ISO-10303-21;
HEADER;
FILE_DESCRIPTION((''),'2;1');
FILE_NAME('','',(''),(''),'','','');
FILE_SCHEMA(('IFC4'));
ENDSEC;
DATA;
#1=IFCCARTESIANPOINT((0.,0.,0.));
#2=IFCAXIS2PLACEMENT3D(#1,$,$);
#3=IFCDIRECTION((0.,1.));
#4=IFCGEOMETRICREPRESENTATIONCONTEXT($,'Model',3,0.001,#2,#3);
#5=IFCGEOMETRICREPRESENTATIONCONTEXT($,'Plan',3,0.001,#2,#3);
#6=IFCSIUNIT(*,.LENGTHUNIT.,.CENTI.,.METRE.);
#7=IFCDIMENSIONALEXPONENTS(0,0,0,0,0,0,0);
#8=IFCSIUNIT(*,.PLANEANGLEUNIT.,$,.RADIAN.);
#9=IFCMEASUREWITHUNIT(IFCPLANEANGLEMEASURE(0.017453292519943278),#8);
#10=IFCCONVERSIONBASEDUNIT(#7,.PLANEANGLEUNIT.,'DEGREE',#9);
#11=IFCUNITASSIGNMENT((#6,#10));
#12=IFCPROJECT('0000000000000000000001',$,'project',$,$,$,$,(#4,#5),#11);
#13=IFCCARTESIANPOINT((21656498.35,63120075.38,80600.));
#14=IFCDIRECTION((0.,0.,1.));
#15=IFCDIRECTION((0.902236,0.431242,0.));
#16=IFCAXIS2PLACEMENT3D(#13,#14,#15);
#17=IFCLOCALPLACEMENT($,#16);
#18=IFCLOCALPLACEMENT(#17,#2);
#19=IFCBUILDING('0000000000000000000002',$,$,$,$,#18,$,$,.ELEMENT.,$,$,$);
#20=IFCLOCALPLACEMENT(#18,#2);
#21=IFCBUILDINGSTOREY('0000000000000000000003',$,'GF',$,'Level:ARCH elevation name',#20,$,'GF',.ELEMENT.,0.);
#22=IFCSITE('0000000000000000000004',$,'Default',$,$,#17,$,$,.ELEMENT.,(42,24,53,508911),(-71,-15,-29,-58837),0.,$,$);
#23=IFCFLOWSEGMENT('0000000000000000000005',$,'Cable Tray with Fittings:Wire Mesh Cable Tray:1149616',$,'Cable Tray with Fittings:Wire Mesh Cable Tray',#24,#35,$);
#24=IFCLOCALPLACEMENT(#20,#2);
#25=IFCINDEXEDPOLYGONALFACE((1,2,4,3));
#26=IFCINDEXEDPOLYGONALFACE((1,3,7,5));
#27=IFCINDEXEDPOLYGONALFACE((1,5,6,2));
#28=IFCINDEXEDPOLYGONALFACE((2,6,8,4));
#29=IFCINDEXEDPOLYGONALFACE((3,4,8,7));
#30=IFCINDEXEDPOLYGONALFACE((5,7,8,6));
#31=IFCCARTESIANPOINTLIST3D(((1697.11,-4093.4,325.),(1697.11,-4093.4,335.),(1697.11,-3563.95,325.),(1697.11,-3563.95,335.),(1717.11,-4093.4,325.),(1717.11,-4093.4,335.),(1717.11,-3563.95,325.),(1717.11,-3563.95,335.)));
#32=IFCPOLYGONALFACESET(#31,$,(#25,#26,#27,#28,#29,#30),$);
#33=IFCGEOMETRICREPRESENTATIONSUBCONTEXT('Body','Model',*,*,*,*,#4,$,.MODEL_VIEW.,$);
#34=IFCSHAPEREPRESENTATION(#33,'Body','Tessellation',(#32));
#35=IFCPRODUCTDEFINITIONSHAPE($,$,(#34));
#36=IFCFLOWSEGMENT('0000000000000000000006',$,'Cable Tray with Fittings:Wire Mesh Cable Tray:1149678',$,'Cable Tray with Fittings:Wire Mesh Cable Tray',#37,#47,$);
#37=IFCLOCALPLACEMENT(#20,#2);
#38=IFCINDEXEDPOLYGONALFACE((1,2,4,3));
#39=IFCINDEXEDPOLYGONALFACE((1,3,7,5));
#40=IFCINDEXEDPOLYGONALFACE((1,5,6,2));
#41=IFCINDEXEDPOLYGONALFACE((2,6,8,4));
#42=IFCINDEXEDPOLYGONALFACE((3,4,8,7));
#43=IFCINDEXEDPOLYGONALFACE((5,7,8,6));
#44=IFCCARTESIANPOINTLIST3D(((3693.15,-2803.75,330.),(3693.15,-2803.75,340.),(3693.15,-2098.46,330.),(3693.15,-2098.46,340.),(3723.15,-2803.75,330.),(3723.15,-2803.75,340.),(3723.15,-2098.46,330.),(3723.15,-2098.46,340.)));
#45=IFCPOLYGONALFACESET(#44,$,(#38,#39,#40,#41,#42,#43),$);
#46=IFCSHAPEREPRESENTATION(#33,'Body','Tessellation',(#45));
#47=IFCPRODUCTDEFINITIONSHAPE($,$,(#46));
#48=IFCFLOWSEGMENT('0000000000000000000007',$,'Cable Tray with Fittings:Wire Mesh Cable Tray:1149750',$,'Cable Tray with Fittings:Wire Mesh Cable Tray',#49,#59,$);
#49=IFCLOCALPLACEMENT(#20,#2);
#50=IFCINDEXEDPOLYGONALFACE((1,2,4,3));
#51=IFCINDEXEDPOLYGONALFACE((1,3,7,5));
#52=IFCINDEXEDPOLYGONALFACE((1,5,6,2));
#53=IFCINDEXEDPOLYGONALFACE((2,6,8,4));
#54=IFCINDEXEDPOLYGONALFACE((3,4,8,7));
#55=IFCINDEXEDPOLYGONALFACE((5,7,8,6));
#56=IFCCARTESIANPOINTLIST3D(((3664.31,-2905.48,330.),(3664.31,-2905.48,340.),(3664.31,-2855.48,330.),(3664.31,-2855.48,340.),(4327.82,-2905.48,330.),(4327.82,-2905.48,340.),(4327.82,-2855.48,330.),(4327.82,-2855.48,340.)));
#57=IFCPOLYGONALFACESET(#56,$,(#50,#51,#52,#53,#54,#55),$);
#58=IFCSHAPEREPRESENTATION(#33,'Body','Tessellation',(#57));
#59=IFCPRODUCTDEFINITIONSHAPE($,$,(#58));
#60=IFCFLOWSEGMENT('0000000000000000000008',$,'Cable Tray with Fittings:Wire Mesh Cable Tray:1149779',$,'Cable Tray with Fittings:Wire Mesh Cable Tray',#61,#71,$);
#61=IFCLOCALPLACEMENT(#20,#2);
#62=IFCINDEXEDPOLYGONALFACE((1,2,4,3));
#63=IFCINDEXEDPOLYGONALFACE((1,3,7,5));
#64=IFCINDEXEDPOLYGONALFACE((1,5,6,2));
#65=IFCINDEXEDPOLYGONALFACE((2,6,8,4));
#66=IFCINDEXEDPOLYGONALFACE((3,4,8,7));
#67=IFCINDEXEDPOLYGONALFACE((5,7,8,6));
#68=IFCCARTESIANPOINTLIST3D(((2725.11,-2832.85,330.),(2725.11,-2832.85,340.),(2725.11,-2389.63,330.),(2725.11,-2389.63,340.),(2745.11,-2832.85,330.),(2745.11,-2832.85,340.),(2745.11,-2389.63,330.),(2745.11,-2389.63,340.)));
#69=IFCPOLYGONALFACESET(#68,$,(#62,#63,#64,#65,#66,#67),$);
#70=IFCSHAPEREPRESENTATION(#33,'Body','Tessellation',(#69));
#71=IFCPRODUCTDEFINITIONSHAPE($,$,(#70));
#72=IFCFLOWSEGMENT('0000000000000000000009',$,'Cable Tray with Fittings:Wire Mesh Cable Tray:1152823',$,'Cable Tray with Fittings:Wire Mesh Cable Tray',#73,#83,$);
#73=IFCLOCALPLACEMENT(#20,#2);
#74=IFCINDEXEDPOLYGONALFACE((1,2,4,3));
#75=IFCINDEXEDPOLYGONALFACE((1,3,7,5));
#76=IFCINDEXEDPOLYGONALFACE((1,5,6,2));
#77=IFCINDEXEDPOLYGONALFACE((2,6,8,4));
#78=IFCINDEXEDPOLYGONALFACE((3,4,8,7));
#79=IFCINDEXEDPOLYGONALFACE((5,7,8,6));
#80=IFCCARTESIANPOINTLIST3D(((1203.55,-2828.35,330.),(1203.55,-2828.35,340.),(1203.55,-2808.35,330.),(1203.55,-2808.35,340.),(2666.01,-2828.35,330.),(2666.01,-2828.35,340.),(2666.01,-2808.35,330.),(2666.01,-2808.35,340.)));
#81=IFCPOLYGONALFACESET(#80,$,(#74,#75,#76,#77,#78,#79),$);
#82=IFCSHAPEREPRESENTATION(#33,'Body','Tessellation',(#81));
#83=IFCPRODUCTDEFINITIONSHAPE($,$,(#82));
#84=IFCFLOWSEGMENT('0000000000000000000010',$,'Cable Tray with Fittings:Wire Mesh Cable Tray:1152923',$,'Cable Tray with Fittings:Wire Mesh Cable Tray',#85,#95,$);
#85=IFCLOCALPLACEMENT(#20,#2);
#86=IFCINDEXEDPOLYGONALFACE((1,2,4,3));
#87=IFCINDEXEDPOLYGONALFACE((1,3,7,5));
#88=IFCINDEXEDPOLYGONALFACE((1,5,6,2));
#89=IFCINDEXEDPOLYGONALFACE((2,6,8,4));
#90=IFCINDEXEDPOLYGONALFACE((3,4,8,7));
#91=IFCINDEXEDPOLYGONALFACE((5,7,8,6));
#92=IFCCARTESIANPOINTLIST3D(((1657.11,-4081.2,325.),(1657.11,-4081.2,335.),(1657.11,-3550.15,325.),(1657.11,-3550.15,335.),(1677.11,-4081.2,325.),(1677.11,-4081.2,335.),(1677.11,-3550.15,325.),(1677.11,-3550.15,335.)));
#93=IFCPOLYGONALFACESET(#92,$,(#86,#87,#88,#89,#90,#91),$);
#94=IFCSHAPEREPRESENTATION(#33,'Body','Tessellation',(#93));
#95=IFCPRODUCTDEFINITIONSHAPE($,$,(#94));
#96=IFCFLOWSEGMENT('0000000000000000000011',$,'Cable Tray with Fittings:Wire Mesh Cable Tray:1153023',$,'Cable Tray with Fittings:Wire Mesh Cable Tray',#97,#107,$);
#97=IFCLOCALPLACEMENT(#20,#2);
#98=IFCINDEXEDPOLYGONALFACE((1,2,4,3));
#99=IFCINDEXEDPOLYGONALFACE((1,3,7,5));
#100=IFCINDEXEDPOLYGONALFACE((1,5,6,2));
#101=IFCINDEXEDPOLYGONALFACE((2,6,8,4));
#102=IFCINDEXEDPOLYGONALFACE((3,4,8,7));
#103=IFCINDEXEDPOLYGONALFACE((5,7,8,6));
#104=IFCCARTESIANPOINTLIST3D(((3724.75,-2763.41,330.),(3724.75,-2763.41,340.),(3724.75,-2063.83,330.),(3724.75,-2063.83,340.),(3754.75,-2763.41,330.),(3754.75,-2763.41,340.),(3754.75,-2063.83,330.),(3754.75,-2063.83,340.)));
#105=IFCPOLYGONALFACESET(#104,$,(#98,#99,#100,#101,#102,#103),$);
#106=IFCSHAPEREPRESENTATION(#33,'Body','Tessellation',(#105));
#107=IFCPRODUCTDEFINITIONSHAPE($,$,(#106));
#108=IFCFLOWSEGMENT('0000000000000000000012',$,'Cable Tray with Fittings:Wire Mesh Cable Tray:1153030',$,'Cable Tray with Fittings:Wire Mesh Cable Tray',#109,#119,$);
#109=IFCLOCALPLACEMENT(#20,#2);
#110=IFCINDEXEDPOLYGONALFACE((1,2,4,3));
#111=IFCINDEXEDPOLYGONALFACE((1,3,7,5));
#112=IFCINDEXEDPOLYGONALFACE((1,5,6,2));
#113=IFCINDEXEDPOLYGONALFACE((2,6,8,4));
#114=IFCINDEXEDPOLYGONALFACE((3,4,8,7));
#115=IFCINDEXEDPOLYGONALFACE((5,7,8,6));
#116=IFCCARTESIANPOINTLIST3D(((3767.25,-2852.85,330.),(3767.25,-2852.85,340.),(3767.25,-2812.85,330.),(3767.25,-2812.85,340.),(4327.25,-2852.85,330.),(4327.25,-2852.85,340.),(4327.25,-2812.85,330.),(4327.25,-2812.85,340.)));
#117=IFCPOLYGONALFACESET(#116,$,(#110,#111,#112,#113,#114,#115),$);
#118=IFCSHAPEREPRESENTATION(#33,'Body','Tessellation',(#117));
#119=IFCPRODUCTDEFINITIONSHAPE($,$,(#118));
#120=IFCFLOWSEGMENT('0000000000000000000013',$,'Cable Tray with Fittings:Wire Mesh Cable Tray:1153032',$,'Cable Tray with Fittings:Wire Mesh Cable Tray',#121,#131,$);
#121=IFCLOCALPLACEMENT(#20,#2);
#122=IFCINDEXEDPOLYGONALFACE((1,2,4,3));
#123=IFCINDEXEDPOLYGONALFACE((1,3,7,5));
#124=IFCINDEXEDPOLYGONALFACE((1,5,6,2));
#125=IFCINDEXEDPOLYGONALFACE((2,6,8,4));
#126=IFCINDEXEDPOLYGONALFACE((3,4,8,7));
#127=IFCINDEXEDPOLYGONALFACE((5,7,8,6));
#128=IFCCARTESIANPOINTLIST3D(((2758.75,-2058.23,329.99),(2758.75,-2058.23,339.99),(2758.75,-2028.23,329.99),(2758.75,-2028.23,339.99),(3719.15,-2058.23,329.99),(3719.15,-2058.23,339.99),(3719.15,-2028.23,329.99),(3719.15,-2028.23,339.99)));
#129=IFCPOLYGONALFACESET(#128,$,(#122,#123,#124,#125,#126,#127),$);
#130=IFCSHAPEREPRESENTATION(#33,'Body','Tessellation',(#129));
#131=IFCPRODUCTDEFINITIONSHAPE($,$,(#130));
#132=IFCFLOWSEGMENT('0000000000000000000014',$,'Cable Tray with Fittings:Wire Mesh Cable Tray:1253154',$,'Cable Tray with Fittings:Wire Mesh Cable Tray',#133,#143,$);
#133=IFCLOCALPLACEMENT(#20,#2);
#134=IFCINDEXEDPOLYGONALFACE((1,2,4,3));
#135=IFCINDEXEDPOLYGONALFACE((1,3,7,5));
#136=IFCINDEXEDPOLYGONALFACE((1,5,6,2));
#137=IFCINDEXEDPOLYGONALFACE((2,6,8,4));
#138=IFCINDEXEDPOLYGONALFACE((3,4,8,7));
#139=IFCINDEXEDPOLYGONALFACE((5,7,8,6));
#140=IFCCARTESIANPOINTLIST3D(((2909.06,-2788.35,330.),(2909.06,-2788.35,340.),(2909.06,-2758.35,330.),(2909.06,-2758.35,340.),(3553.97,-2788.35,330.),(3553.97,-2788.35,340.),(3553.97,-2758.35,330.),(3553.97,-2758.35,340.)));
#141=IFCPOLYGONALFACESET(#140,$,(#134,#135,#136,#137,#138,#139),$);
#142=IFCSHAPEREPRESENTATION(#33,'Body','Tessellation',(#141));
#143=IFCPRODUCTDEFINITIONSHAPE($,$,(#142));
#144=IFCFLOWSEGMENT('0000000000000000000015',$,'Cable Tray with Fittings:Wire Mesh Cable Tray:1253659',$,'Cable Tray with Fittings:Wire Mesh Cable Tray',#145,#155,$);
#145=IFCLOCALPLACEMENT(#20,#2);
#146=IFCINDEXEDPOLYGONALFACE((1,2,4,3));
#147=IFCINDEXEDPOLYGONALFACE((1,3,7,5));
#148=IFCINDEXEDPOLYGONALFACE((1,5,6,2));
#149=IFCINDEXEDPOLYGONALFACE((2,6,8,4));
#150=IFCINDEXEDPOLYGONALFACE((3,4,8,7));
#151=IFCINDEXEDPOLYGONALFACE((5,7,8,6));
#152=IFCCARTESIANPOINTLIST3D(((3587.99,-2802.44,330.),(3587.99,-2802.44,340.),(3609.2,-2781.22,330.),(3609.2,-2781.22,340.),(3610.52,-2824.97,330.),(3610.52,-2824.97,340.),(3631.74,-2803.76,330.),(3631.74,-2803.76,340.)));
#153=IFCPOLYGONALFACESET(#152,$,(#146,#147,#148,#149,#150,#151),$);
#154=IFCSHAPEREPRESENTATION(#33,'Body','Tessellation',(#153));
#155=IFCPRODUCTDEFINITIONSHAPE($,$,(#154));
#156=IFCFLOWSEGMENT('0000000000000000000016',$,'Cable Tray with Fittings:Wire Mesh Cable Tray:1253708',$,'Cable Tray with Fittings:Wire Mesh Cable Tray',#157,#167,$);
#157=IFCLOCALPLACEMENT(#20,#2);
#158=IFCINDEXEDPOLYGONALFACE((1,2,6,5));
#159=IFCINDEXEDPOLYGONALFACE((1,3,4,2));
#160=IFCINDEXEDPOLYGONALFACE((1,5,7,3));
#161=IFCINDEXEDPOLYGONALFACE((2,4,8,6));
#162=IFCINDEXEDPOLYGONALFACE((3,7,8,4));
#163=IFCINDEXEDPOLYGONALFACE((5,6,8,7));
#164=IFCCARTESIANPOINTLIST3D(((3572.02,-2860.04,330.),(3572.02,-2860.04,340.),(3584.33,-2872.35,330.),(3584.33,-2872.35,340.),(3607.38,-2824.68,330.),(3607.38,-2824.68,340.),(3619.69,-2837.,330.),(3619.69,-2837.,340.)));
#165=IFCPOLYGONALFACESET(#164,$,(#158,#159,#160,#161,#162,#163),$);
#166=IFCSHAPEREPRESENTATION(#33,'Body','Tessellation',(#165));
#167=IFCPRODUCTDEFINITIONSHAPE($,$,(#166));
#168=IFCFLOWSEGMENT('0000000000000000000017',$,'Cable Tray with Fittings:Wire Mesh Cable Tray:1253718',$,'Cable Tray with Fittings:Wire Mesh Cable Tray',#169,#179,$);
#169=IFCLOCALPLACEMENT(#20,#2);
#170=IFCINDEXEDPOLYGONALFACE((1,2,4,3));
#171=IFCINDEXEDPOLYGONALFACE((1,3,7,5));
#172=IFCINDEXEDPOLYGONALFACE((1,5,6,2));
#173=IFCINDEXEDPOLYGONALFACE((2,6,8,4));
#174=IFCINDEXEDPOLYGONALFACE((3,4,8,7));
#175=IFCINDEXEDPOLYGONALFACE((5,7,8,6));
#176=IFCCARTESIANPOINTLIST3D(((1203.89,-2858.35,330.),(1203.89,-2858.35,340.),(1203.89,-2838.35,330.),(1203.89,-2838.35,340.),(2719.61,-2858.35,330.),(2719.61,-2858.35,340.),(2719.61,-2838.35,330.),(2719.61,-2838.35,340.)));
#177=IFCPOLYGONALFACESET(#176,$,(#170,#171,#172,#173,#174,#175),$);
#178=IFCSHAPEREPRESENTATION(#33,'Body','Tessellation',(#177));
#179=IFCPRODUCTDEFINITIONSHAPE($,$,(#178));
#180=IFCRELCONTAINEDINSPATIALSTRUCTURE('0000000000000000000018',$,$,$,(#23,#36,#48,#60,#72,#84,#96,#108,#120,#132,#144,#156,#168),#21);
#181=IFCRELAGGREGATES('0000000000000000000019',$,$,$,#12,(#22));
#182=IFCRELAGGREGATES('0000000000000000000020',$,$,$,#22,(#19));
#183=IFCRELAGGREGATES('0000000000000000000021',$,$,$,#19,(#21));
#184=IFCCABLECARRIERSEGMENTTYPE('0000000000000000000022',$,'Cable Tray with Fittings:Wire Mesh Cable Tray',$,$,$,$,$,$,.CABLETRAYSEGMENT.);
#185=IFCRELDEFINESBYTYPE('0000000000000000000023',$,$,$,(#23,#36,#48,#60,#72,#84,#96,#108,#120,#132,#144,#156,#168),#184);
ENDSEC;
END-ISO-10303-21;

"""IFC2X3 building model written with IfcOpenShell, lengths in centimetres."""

from ifc_helpers import new_model, entity, si_unit, converted_unit, direction, frame, frame_2d, origin, origin_2d_with_axis, place, context, subcontext, project, spatial, rectangle, extrude, type_object, element, save


model = new_model("IFC2X3")

# Units and contexts
model_context = context("Model", 3, precision=0.001, world=origin(), true_north=direction((0.0, 1.0)))
plan_context = context("Plan", 3, precision=0.001, world=origin(), true_north=direction((0.0, 1.0)))
body_context = subcontext(model_context, "Body", "Model", "MODEL_VIEW")
ifc_project = project(units=[si_unit("LENGTHUNIT", "METRE", prefix="CENTI"), converted_unit("PLANEANGLEUNIT", "DEGREE", entity("IfcPlaneAngleMeasure", 0.017453292519943278), si_unit("PLANEANGLEUNIT", "RADIAN"), dimensions=[0, 0, 0, 0, 0, 0, 0])], contexts=[model_context, plan_context])

# Site, building, storey
site_placement = place(None, frame((21656498.35, 63120075.38, 80600.0), z_axis=(0.0, 0.0, 1.0), x_axis=(0.902236, 0.431242, 0.0)))
site = spatial("IfcSite", under=ifc_project, at=site_placement, Name="Default", CompositionType="ELEMENT", RefLatitude=(42, 24, 53, 508911), RefLongitude=(-71, -15, -29, -58837), RefElevation=0.0)
building_placement = place(site_placement, origin())
building = spatial("IfcBuilding", under=site, at=building_placement, CompositionType="ELEMENT")
storey_placement = place(building_placement, origin())
storey = spatial("IfcBuildingStorey", under=building, at=storey_placement, Name="GF", ObjectType="Level:ARCH elevation name", LongName="GF", CompositionType="ELEMENT", Elevation=0.0)

# Flow segments
cable_carrier_segment_type_1 = type_object("IfcCableCarrierSegmentType", Name="Cable Tray with Fittings:Wire Mesh Cable Tray", PredefinedType="CABLETRAYSEGMENT")
flow_segment_1_placement = place(storey_placement, origin())
element("IfcFlowSegment", 1, at=flow_segment_1_placement, inside=storey, type_object=cable_carrier_segment_type_1, Name="Cable Tray with Fittings:Wire Mesh Cable Tray:1149616", ObjectType="Cable Tray with Fittings:Wire Mesh Cable Tray", context=body_context, shape_type="SweptSolid", body=[
    extrude(rectangle(XDim=529.45, YDim=20.0, at=frame_2d((0.0, 0.0), x_axis=(1.0, 0.0))), frame((1707.11, -3828.68, 325.0), z_axis=(0.0, 0.0, 1.0), x_axis=(0.0, 1.0, 0.0)), (0.0, 0.0, 1.0), 10.0),
])
flow_segment_2_placement = place(storey_placement, origin())
element("IfcFlowSegment", 2, at=flow_segment_2_placement, inside=storey, type_object=cable_carrier_segment_type_1, Name="Cable Tray with Fittings:Wire Mesh Cable Tray:1149678", ObjectType="Cable Tray with Fittings:Wire Mesh Cable Tray", context=body_context, shape_type="SweptSolid", body=[
    extrude(rectangle(XDim=705.29, YDim=30.0, at=frame_2d((0.0, 0.0), x_axis=(1.0, 0.0))), frame((3708.15, -2451.1, 330.0), z_axis=(0.0, 0.0, 1.0), x_axis=(0.0, -1.0, 0.0)), (0.0, 0.0, 1.0), 10.0),
])
flow_segment_3_placement = place(storey_placement, origin())
element("IfcFlowSegment", 3, at=flow_segment_3_placement, inside=storey, type_object=cable_carrier_segment_type_1, Name="Cable Tray with Fittings:Wire Mesh Cable Tray:1149750", ObjectType="Cable Tray with Fittings:Wire Mesh Cable Tray", context=body_context, shape_type="SweptSolid", body=[
    extrude(rectangle(XDim=663.51, YDim=50.0, at=frame_2d((0.0, 0.0), x_axis=(1.0, 0.0))), frame((3996.06, -2880.48, 330.0)), (0.0, 0.0, 1.0), 10.0),
])
flow_segment_4_placement = place(storey_placement, origin())
element("IfcFlowSegment", 4, at=flow_segment_4_placement, inside=storey, type_object=cable_carrier_segment_type_1, Name="Cable Tray with Fittings:Wire Mesh Cable Tray:1149779", ObjectType="Cable Tray with Fittings:Wire Mesh Cable Tray", context=body_context, shape_type="SweptSolid", body=[
    extrude(rectangle(XDim=443.22, YDim=20.0, at=origin_2d_with_axis()), frame((2735.11, -2611.24, 330.0), z_axis=(0.0, 0.0, 1.0), x_axis=(0.0, 1.0, 0.0)), (0.0, 0.0, 1.0), 10.0),
])
flow_segment_5_placement = place(storey_placement, origin())
element("IfcFlowSegment", 5, at=flow_segment_5_placement, inside=storey, type_object=cable_carrier_segment_type_1, Name="Cable Tray with Fittings:Wire Mesh Cable Tray:1152823", ObjectType="Cable Tray with Fittings:Wire Mesh Cable Tray", context=body_context, shape_type="SweptSolid", body=[
    extrude(rectangle(XDim=1462.46, YDim=20.0, at=frame_2d((0.0, 0.0), x_axis=(1.0, 0.0))), frame((1934.78, -2818.35, 330.0), z_axis=(0.0, 0.0, 1.0), x_axis=(-1.0, 0.0, 0.0)), (0.0, 0.0, 1.0), 10.0),
])
flow_segment_6_placement = place(storey_placement, origin())
element("IfcFlowSegment", 6, at=flow_segment_6_placement, inside=storey, type_object=cable_carrier_segment_type_1, Name="Cable Tray with Fittings:Wire Mesh Cable Tray:1152923", ObjectType="Cable Tray with Fittings:Wire Mesh Cable Tray", context=body_context, shape_type="SweptSolid", body=[
    extrude(rectangle(XDim=531.05, YDim=20.0, at=frame_2d((0.0, 0.0), x_axis=(1.0, 0.0))), frame((1667.11, -3815.68, 325.0), z_axis=(0.0, 0.0, 1.0), x_axis=(0.0, 1.0, 0.0)), (0.0, 0.0, 1.0), 10.0),
])
flow_segment_7_placement = place(storey_placement, origin())
element("IfcFlowSegment", 7, at=flow_segment_7_placement, inside=storey, type_object=cable_carrier_segment_type_1, Name="Cable Tray with Fittings:Wire Mesh Cable Tray:1153023", ObjectType="Cable Tray with Fittings:Wire Mesh Cable Tray", context=body_context, shape_type="SweptSolid", body=[
    extrude(rectangle(XDim=699.58, YDim=30.0, at=origin_2d_with_axis()), frame((3739.75, -2413.62, 330.0), z_axis=(0.0, 0.0, 1.0), x_axis=(0.0, -1.0, 0.0)), (0.0, 0.0, 1.0), 10.0),
])
flow_segment_8_placement = place(storey_placement, origin())
element("IfcFlowSegment", 8, at=flow_segment_8_placement, inside=storey, type_object=cable_carrier_segment_type_1, Name="Cable Tray with Fittings:Wire Mesh Cable Tray:1153030", ObjectType="Cable Tray with Fittings:Wire Mesh Cable Tray", context=body_context, shape_type="SweptSolid", body=[
    extrude(rectangle(XDim=560.0, YDim=40.0, at=frame_2d((0.0, 0.0), x_axis=(1.0, 0.0))), frame((4047.25, -2832.85, 330.0)), (0.0, 0.0, 1.0), 10.0),
])
flow_segment_9_placement = place(storey_placement, origin())
element("IfcFlowSegment", 9, at=flow_segment_9_placement, inside=storey, type_object=cable_carrier_segment_type_1, Name="Cable Tray with Fittings:Wire Mesh Cable Tray:1153032", ObjectType="Cable Tray with Fittings:Wire Mesh Cable Tray", context=body_context, shape_type="SweptSolid", body=[
    extrude(rectangle(XDim=960.4, YDim=30.0, at=frame_2d((0.0, 0.0), x_axis=(1.0, 0.0))), frame((3238.95, -2043.23, 329.99), z_axis=(0.0, 0.0, 1.0), x_axis=(-1.0, 0.0, 0.0)), (0.0, 0.0, 1.0), 10.0),
])
flow_segment_10_placement = place(storey_placement, origin())
element("IfcFlowSegment", 10, at=flow_segment_10_placement, inside=storey, type_object=cable_carrier_segment_type_1, Name="Cable Tray with Fittings:Wire Mesh Cable Tray:1253154", ObjectType="Cable Tray with Fittings:Wire Mesh Cable Tray", context=body_context, shape_type="SweptSolid", body=[
    extrude(rectangle(XDim=644.91, YDim=30.0, at=frame_2d((0.0, 0.0), x_axis=(1.0, 0.0))), frame((3231.52, -2773.35, 330.0), z_axis=(0.0, 0.0, 1.0), x_axis=(-1.0, 0.0, 0.0)), (0.0, 0.0, 1.0), 10.0),
])
flow_segment_11_placement = place(storey_placement, origin())
element("IfcFlowSegment", 11, at=flow_segment_11_placement, inside=storey, type_object=cable_carrier_segment_type_1, Name="Cable Tray with Fittings:Wire Mesh Cable Tray:1253659", ObjectType="Cable Tray with Fittings:Wire Mesh Cable Tray", context=body_context, shape_type="SweptSolid", body=[
    extrude(rectangle(XDim=31.87, YDim=30.0, at=frame_2d((0.0, 0.0), x_axis=(1.0, 0.0))), frame((3609.86, -2803.1, 330.0), z_axis=(0.0, 0.0, 1.0), x_axis=(-0.707107, 0.707107, 0.0)), (0.0, 0.0, 1.0), 10.0),
])
flow_segment_12_placement = place(storey_placement, origin())
element("IfcFlowSegment", 12, at=flow_segment_12_placement, inside=storey, type_object=cable_carrier_segment_type_1, Name="Cable Tray with Fittings:Wire Mesh Cable Tray:1253708", ObjectType="Cable Tray with Fittings:Wire Mesh Cable Tray", context=body_context, shape_type="SweptSolid", body=[
    extrude(rectangle(XDim=17.41, YDim=50.0, at=frame_2d((0.0, 0.0), x_axis=(1.0, 0.0))), frame((3595.86, -2848.52, 330.0), z_axis=(0.0, 0.0, 1.0), x_axis=(-0.707107, 0.707107, 0.0)), (0.0, 0.0, 1.0), 10.0),
])
flow_segment_13_placement = place(storey_placement, origin())
element("IfcFlowSegment", 13, at=flow_segment_13_placement, inside=storey, type_object=cable_carrier_segment_type_1, Name="Cable Tray with Fittings:Wire Mesh Cable Tray:1253718", ObjectType="Cable Tray with Fittings:Wire Mesh Cable Tray", context=body_context, shape_type="SweptSolid", body=[
    extrude(rectangle(XDim=1515.72, YDim=20.0, at=origin_2d_with_axis()), frame((1961.75, -2848.35, 330.0), z_axis=(0.0, 0.0, 1.0), x_axis=(-1.0, 0.0, 0.0)), (0.0, 0.0, 1.0), 10.0),
])

save(model, "model.ifc")
